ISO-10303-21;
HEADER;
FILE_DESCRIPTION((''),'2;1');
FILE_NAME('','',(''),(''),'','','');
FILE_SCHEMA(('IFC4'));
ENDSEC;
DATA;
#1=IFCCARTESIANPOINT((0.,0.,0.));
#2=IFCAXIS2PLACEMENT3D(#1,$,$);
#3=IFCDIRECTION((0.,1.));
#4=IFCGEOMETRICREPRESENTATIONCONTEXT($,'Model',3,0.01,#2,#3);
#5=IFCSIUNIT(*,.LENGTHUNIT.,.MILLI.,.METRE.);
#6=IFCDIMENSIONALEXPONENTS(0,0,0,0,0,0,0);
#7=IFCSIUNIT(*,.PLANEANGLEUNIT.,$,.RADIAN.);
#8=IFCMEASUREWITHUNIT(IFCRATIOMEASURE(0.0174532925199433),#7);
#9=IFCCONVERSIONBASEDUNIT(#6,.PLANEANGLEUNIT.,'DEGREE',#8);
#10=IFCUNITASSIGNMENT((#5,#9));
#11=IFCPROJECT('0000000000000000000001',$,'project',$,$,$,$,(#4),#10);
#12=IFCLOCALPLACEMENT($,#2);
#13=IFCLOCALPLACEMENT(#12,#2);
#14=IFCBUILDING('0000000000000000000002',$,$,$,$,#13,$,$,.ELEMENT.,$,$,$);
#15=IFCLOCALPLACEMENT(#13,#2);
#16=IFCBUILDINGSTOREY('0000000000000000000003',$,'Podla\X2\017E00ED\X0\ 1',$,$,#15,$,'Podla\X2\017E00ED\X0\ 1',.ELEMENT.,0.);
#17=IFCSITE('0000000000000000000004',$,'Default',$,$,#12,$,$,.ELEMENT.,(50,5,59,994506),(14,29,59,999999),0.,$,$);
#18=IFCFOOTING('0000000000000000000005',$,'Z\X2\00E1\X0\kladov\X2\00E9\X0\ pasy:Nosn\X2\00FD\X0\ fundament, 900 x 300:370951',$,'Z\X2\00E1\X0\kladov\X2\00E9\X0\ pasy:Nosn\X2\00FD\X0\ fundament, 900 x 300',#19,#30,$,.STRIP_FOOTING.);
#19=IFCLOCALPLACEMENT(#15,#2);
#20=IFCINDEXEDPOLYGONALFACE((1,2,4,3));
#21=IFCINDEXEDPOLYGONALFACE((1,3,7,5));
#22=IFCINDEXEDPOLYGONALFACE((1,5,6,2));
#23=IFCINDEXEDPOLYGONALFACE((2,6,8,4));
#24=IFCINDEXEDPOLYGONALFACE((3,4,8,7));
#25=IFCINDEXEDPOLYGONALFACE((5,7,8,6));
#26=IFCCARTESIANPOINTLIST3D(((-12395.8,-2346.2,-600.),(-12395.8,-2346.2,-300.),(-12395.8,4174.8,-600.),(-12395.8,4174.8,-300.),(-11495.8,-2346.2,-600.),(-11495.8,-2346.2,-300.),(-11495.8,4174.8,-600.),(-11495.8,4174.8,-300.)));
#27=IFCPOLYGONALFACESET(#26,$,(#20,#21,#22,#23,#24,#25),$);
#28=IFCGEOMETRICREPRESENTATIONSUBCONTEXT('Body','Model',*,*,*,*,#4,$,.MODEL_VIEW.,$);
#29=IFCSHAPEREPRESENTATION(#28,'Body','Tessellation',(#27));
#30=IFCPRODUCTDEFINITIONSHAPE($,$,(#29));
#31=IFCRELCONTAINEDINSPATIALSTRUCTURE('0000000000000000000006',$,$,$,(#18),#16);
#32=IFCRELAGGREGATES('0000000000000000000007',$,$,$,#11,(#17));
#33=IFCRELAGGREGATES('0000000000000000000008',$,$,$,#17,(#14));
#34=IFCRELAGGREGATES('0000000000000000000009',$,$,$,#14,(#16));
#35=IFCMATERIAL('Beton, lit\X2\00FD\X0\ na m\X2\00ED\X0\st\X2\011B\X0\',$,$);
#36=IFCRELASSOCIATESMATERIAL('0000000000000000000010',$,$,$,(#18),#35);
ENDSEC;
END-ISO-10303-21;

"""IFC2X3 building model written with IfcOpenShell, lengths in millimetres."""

from ifc_helpers import new_model, entity, si_unit, converted_unit, direction, frame, frame_2d, origin, place, context, subcontext, project, spatial, rectangle, extrude, material, element, save


model = new_model("IFC2X3")

# Units and contexts
model_context = context("Model", 3, precision=0.01, world=origin(), true_north=direction((0.0, 1.0)))
body_context = subcontext(model_context, "Body", "Model", "MODEL_VIEW")
ifc_project = project(units=[si_unit("LENGTHUNIT", "METRE", prefix="MILLI"), converted_unit("PLANEANGLEUNIT", "DEGREE", entity("IfcRatioMeasure", 0.0174532925199433), si_unit("PLANEANGLEUNIT", "RADIAN"), dimensions=[0, 0, 0, 0, 0, 0, 0])], contexts=[model_context])

# Site, building, storey
site_placement = place(None, origin())
site = spatial("IfcSite", under=ifc_project, at=site_placement, Name="Default", CompositionType="ELEMENT", RefLatitude=(50, 5, 59, 994506), RefLongitude=(14, 29, 59, 999999), RefElevation=0.0)
building_placement = place(site_placement, origin())
building = spatial("IfcBuilding", under=site, at=building_placement, CompositionType="ELEMENT")
storey_placement = place(building_placement, origin())
storey = spatial("IfcBuildingStorey", under=building, at=storey_placement, Name="Podlaží 1", LongName="Podlaží 1", CompositionType="ELEMENT", Elevation=0.0)

# Footing
ifc_material_1 = material(Name="Beton, litý na místě")
footing_1_placement = place(storey_placement, origin())
element("IfcFooting", 1, at=footing_1_placement, inside=storey, material=ifc_material_1, Name="Základové pasy:Nosný fundament, 900 x 300:370951", ObjectType="Základové pasy:Nosný fundament, 900 x 300", PredefinedType="STRIP_FOOTING", context=body_context, shape_type="SweptSolid", body=[
    extrude(rectangle(XDim=6521.0, YDim=900.0, at=frame_2d((0.0, -150.0), x_axis=(1.0, 0.0))), frame((-11795.8, 914.3, -600.0), z_axis=(0.0, 0.0, 1.0), x_axis=(0.0, -1.0, 0.0)), (0.0, 0.0, 1.0), 300.0),
])

save(model, "model.ifc")
